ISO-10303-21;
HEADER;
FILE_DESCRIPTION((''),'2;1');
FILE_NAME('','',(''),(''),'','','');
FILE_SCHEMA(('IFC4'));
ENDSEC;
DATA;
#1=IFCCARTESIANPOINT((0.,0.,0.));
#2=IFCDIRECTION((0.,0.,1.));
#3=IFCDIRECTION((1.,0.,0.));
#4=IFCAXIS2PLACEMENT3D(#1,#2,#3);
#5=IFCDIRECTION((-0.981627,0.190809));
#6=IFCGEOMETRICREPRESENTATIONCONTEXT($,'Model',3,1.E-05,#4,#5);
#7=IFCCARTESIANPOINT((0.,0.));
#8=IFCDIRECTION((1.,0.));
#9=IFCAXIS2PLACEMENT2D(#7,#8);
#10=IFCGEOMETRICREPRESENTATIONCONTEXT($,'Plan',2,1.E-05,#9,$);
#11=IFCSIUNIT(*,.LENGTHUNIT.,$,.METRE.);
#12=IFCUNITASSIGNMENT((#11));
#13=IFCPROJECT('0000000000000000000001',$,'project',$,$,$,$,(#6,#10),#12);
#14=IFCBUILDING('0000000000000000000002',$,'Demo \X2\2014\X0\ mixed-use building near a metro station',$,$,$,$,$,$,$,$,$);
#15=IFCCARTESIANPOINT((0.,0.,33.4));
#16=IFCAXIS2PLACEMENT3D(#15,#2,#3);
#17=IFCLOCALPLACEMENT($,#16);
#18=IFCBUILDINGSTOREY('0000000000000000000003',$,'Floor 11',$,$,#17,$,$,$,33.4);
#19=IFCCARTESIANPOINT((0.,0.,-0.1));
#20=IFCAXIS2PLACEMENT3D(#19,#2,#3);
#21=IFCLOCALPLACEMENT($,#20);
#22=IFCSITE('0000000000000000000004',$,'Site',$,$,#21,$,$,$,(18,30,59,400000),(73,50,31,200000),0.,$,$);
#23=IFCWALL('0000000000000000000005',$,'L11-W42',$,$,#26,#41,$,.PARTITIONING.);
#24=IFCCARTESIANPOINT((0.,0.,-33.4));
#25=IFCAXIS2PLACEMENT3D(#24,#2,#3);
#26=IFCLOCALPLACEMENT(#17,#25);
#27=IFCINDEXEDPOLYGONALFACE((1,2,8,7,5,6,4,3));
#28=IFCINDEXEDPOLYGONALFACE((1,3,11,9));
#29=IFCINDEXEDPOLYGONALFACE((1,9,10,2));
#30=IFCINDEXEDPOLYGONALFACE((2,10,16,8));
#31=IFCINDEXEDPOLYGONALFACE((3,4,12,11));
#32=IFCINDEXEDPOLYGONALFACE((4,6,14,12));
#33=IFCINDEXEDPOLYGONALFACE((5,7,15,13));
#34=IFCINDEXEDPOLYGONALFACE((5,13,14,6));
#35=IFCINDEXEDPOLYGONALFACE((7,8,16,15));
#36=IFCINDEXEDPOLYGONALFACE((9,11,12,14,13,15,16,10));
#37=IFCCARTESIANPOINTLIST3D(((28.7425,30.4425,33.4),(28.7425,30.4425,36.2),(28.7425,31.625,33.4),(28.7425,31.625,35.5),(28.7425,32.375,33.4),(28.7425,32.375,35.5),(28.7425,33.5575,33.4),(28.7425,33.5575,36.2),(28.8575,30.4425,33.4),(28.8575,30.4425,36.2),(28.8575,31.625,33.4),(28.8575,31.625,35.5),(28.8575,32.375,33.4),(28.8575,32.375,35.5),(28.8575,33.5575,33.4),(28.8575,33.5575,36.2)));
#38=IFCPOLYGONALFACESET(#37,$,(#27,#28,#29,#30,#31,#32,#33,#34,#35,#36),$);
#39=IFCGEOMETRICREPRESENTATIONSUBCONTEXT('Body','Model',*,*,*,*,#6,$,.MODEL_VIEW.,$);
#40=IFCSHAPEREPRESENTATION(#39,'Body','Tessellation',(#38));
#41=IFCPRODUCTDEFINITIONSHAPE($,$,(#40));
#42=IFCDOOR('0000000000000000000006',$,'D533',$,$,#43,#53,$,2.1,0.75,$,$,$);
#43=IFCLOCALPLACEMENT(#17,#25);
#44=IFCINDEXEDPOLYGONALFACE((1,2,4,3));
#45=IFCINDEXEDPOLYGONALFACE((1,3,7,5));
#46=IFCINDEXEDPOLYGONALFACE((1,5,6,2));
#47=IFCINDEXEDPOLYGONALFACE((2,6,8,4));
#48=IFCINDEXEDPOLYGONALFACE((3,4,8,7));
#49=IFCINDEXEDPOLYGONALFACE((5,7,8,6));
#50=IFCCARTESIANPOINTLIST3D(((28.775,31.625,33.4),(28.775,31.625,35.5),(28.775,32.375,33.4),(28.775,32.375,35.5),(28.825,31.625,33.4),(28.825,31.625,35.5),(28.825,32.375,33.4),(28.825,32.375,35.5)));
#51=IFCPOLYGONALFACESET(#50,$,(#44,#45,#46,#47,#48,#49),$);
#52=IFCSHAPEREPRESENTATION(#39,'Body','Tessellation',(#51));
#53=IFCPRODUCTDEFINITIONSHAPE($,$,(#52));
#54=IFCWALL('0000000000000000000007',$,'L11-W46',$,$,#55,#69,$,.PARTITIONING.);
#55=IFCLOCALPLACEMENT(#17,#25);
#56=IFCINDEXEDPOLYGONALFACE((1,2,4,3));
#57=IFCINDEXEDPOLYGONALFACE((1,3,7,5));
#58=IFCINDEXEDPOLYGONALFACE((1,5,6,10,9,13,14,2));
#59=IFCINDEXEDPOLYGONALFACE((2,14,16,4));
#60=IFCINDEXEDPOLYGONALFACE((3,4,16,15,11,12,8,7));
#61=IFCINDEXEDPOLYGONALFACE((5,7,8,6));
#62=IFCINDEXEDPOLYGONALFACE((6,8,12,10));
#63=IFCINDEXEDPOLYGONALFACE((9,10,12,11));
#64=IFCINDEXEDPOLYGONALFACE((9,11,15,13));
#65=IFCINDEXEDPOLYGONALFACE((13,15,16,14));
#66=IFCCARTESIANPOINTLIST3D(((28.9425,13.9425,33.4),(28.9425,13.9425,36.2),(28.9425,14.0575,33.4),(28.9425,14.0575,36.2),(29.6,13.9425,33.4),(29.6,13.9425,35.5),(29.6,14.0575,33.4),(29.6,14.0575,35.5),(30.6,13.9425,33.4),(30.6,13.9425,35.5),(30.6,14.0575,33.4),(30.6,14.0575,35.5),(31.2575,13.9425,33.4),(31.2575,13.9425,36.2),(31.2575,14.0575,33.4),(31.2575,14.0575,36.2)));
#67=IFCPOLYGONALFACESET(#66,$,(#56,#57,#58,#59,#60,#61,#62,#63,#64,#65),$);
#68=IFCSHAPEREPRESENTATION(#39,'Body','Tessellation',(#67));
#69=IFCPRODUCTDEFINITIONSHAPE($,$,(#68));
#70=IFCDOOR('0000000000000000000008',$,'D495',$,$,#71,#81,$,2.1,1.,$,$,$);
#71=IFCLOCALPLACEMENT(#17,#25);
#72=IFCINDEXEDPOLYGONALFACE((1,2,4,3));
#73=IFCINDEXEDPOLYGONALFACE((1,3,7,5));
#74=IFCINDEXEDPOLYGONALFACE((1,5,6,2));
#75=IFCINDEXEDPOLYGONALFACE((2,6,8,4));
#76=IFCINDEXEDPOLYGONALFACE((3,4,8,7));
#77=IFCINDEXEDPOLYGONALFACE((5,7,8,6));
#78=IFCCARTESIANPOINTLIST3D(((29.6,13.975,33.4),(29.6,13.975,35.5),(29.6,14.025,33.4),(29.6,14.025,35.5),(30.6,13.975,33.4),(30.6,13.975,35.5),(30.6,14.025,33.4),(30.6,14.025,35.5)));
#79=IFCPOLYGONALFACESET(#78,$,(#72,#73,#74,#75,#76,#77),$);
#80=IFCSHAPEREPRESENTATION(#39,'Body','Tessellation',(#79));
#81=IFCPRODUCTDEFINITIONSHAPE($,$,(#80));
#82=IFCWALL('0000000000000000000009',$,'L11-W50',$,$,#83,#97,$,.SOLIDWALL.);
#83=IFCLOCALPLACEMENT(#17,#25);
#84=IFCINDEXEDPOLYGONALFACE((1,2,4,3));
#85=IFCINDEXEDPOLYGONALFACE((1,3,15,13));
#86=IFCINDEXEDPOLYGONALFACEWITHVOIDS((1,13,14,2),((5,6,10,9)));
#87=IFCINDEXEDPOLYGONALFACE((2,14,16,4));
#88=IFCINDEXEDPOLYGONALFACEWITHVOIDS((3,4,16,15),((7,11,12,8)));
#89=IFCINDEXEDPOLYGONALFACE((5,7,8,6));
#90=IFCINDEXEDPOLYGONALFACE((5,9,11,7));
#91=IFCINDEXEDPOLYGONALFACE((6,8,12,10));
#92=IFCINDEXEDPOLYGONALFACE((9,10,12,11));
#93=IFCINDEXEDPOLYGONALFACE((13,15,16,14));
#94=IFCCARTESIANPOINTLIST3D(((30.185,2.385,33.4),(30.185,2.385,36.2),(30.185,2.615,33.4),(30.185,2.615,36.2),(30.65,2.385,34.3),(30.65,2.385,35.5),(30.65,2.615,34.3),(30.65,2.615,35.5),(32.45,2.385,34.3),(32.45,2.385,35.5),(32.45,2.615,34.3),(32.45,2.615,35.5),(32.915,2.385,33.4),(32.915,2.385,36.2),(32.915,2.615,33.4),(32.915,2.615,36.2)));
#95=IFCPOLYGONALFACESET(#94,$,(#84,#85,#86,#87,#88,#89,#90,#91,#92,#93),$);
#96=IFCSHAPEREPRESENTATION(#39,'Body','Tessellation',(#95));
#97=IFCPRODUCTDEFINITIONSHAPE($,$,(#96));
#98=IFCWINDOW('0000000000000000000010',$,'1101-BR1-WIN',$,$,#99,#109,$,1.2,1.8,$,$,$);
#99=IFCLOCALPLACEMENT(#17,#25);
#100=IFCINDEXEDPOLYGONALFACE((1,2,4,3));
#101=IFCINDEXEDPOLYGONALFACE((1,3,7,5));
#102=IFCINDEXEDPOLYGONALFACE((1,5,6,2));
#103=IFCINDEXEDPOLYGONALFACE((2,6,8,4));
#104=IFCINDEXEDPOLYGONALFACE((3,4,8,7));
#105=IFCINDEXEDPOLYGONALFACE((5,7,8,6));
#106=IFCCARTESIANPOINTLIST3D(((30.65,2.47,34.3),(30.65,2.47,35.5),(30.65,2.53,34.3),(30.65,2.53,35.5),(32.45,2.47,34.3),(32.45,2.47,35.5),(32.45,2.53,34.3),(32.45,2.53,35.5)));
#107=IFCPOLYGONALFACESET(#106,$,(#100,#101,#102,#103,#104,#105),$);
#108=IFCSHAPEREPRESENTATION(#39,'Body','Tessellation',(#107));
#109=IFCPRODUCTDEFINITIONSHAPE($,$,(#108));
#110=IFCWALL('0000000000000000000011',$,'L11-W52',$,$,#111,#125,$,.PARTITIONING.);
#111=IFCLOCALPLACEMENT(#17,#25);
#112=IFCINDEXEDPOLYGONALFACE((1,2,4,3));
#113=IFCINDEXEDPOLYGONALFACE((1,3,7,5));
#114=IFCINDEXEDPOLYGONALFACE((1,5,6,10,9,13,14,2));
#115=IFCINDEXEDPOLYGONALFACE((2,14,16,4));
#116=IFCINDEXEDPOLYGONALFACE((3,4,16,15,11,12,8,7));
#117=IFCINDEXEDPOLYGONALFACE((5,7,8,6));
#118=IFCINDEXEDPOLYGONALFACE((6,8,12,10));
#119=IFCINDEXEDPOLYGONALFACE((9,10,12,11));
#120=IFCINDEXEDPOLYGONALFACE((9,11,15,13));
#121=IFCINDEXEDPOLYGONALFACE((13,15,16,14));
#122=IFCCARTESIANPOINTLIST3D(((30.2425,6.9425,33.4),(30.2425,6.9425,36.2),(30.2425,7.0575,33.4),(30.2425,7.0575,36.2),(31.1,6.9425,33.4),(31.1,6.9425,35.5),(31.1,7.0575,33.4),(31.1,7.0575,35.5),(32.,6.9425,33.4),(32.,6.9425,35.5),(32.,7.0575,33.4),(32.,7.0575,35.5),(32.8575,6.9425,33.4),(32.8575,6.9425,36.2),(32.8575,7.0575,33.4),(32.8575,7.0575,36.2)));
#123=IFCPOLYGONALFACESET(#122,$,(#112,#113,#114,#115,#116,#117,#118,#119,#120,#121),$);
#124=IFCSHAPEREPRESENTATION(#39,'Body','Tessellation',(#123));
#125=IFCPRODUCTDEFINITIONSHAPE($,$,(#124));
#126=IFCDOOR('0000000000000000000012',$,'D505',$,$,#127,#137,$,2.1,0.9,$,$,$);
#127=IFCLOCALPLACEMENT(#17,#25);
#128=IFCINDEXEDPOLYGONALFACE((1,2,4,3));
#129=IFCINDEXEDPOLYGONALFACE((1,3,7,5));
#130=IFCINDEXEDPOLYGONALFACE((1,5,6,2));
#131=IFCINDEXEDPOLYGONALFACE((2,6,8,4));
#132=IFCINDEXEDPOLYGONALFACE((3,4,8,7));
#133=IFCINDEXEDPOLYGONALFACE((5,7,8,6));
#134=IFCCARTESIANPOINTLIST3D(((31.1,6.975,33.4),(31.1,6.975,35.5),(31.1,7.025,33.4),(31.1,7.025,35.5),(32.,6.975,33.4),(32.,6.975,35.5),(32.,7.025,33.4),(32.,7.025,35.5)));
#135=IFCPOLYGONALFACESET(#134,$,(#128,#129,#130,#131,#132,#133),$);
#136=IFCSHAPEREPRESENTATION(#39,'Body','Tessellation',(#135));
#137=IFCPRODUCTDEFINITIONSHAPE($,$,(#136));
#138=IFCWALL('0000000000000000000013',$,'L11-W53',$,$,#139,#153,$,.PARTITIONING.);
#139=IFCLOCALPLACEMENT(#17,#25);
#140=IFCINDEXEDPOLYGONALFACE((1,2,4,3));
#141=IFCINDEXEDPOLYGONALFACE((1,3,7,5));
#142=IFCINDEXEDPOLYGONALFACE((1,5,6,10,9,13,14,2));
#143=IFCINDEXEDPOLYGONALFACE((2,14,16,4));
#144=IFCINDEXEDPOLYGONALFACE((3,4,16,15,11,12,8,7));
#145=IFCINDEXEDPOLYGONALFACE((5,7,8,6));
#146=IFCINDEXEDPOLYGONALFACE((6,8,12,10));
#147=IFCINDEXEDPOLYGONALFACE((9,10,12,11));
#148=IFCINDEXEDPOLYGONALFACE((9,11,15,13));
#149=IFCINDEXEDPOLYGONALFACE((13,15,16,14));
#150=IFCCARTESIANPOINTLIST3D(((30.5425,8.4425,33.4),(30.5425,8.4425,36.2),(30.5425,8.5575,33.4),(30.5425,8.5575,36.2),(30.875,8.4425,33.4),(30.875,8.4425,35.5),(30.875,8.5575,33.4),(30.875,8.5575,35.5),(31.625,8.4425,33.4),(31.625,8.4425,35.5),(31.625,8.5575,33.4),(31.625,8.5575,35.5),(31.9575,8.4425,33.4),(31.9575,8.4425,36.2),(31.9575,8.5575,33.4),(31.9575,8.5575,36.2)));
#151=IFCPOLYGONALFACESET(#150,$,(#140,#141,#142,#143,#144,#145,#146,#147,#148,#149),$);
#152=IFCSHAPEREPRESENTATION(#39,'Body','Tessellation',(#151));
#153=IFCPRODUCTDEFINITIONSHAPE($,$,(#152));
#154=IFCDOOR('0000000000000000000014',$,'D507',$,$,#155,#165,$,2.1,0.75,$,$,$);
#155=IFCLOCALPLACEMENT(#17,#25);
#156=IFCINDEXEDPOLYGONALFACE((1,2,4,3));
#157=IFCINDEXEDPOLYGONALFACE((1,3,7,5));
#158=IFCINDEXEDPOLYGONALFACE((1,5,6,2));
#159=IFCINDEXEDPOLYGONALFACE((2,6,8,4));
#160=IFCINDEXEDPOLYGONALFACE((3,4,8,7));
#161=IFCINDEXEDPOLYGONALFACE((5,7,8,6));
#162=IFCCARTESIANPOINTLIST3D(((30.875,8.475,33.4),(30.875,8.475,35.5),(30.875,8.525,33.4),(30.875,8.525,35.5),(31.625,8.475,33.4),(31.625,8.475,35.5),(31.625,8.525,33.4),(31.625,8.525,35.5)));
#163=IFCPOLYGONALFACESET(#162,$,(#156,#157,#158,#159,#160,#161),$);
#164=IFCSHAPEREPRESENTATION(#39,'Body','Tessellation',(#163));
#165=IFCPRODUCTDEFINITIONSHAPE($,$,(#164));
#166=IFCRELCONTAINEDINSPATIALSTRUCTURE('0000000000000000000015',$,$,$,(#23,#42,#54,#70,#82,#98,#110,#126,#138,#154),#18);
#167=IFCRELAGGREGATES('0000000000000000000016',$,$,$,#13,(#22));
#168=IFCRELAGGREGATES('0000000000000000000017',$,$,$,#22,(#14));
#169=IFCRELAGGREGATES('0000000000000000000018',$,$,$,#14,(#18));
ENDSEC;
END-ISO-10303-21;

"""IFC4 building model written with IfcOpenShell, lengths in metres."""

from ifc_helpers import new_model, si_unit, direction, frame, origin_with_axes, origin_2d_with_axis, place, context, subcontext, project, spatial, line, indexed_curve, outline, extrude, element, fill, save


model = new_model("IFC4")

# Units and contexts
model_context = context("Model", 3, precision=1e-05, world=origin_with_axes(), true_north=direction((-0.981627, 0.190809)))
plan_context = context("Plan", 2, precision=1e-05, world=origin_2d_with_axis())
body_context = subcontext(model_context, "Body", "Model", "MODEL_VIEW")
ifc_project = project(units=[si_unit("LENGTHUNIT", "METRE")], contexts=[model_context, plan_context])

# Site, building, storey
site_placement = place(None, frame((0.0, 0.0, -0.1), z_axis=(0.0, 0.0, 1.0), x_axis=(1.0, 0.0, 0.0)))
site = spatial("IfcSite", under=ifc_project, at=site_placement, Name="Site", RefLatitude=(18, 30, 59, 400000), RefLongitude=(73, 50, 31, 200000), RefElevation=0.0)
building = spatial("IfcBuilding", under=site, Name="Demo — mixed-use building near a metro station")
storey_placement = place(None, frame((0.0, 0.0, 33.4), z_axis=(0.0, 0.0, 1.0), x_axis=(1.0, 0.0, 0.0)))
storey = spatial("IfcBuildingStorey", under=building, at=storey_placement, Name="Floor 11", Elevation=33.4)

# Wall, opening, door
wall_1_placement = place(storey_placement, frame((0.0, 0.0, -33.4), z_axis=(0.0, 0.0, 1.0), x_axis=(1.0, 0.0, 0.0)))
wall_1 = element("IfcWall", 1, at=wall_1_placement, inside=storey, Name="L11-W42", PredefinedType="PARTITIONING", context=body_context, shape_type="SweptSolid", body=[
    extrude(outline(indexed_curve([(28.7425, 30.4425), (28.7425, 33.5575), (28.8575, 33.5575), (28.8575, 30.4425)], segments=[line(1, 2, 3, 4, 1)])), frame((0.0, 0.0, 33.4), z_axis=(0.0, 0.0, 1.0), x_axis=(1.0, 0.0, 0.0)), (0.0, 0.0, 1.0), 2.8),
])
opening_1_placement = place(wall_1_placement, origin_with_axes())
opening_1 = element("IfcOpeningElement", 2, at=opening_1_placement, cuts=wall_1, context=body_context, shape_type="SweptSolid", body=[
    extrude(outline(indexed_curve([(28.6925, 31.625), (28.6925, 32.375), (28.9075, 32.375), (28.9075, 31.625)], segments=[line(1, 2, 3, 4, 1)])), frame((0.0, 0.0, 33.4), z_axis=(0.0, 0.0, 1.0), x_axis=(1.0, 0.0, 0.0)), (0.0, 0.0, 1.0), 2.1),
])
door_1_placement = place(storey_placement, frame((0.0, 0.0, -33.4), z_axis=(0.0, 0.0, 1.0), x_axis=(1.0, 0.0, 0.0)))
door_1 = element("IfcDoor", 3, at=door_1_placement, inside=storey, Name="D533", OverallHeight=2.1, OverallWidth=0.75, context=body_context, shape_type="SweptSolid", body=[
    extrude(outline(indexed_curve([(28.775, 31.625), (28.775, 32.375), (28.825, 32.375), (28.825, 31.625)], segments=[line(1, 2, 3, 4, 1)])), frame((0.0, 0.0, 33.4), z_axis=(0.0, 0.0, 1.0), x_axis=(1.0, 0.0, 0.0)), (0.0, 0.0, 1.0), 2.1),
])
fill(opening_1, door_1)

# Wall, opening, door
wall_2_placement = place(storey_placement, frame((0.0, 0.0, -33.4), z_axis=(0.0, 0.0, 1.0), x_axis=(1.0, 0.0, 0.0)))
wall_2 = element("IfcWall", 4, at=wall_2_placement, inside=storey, Name="L11-W46", PredefinedType="PARTITIONING", context=body_context, shape_type="SweptSolid", body=[
    extrude(outline(indexed_curve([(31.2575, 13.9425), (28.9425, 13.9425), (28.9425, 14.0575), (31.2575, 14.0575)], segments=[line(1, 2, 3, 4, 1)])), frame((0.0, 0.0, 33.4), z_axis=(0.0, 0.0, 1.0), x_axis=(1.0, 0.0, 0.0)), (0.0, 0.0, 1.0), 2.8),
])
opening_2_placement = place(wall_2_placement, origin_with_axes())
opening_2 = element("IfcOpeningElement", 5, at=opening_2_placement, cuts=wall_2, context=body_context, shape_type="SweptSolid", body=[
    extrude(outline(indexed_curve([(30.6, 13.8925), (29.6, 13.8925), (29.6, 14.1075), (30.6, 14.1075)], segments=[line(1, 2, 3, 4, 1)])), frame((0.0, 0.0, 33.4), z_axis=(0.0, 0.0, 1.0), x_axis=(1.0, 0.0, 0.0)), (0.0, 0.0, 1.0), 2.1),
])
door_2_placement = place(storey_placement, frame((0.0, 0.0, -33.4), z_axis=(0.0, 0.0, 1.0), x_axis=(1.0, 0.0, 0.0)))
door_2 = element("IfcDoor", 6, at=door_2_placement, inside=storey, Name="D495", OverallHeight=2.1, OverallWidth=1.0, context=body_context, shape_type="SweptSolid", body=[
    extrude(outline(indexed_curve([(30.6, 13.975), (29.6, 13.975), (29.6, 14.025), (30.6, 14.025)], segments=[line(1, 2, 3, 4, 1)])), frame((0.0, 0.0, 33.4), z_axis=(0.0, 0.0, 1.0), x_axis=(1.0, 0.0, 0.0)), (0.0, 0.0, 1.0), 2.1),
])
fill(opening_2, door_2)

# Wall, opening, window
wall_3_placement = place(storey_placement, frame((0.0, 0.0, -33.4), z_axis=(0.0, 0.0, 1.0), x_axis=(1.0, 0.0, 0.0)))
wall_3 = element("IfcWall", 7, at=wall_3_placement, inside=storey, Name="L11-W50", PredefinedType="SOLIDWALL", context=body_context, shape_type="SweptSolid", body=[
    extrude(outline(indexed_curve([(30.185, 2.615), (32.915, 2.615), (32.915, 2.385), (30.185, 2.385)], segments=[line(1, 2, 3, 4, 1)])), frame((0.0, 0.0, 33.4), z_axis=(0.0, 0.0, 1.0), x_axis=(1.0, 0.0, 0.0)), (0.0, 0.0, 1.0), 2.8),
])
opening_3_placement = place(wall_3_placement, origin_with_axes())
opening_3 = element("IfcOpeningElement", 8, at=opening_3_placement, cuts=wall_3, context=body_context, shape_type="SweptSolid", body=[
    extrude(outline(indexed_curve([(30.65, 2.665), (32.45, 2.665), (32.45, 2.335), (30.65, 2.335)], segments=[line(1, 2, 3, 4, 1)])), frame((0.0, 0.0, 34.3), z_axis=(0.0, 0.0, 1.0), x_axis=(1.0, 0.0, 0.0)), (0.0, 0.0, 1.0), 1.2),
])
window_placement = place(storey_placement, frame((0.0, 0.0, -33.4), z_axis=(0.0, 0.0, 1.0), x_axis=(1.0, 0.0, 0.0)))
window = element("IfcWindow", 9, at=window_placement, inside=storey, Name="1101-BR1-WIN", OverallHeight=1.2, OverallWidth=1.8, context=body_context, shape_type="SweptSolid", body=[
    extrude(outline(indexed_curve([(30.65, 2.53), (32.45, 2.53), (32.45, 2.47), (30.65, 2.47)], segments=[line(1, 2, 3, 4, 1)])), frame((0.0, 0.0, 34.3), z_axis=(0.0, 0.0, 1.0), x_axis=(1.0, 0.0, 0.0)), (0.0, 0.0, 1.0), 1.2),
])
fill(opening_3, window)

# Walls, openings, doors
wall_4_placement = place(storey_placement, frame((0.0, 0.0, -33.4), z_axis=(0.0, 0.0, 1.0), x_axis=(1.0, 0.0, 0.0)))
wall_4 = element("IfcWall", 10, at=wall_4_placement, inside=storey, Name="L11-W52", PredefinedType="PARTITIONING", context=body_context, shape_type="SweptSolid", body=[
    extrude(outline(indexed_curve([(32.8575, 6.9425), (30.2425, 6.9425), (30.2425, 7.0575), (32.8575, 7.0575)], segments=[line(1, 2, 3, 4, 1)])), frame((0.0, 0.0, 33.4), z_axis=(0.0, 0.0, 1.0), x_axis=(1.0, 0.0, 0.0)), (0.0, 0.0, 1.0), 2.8),
])
opening_4_placement = place(wall_4_placement, origin_with_axes())
opening_4 = element("IfcOpeningElement", 11, at=opening_4_placement, cuts=wall_4, context=body_context, shape_type="SweptSolid", body=[
    extrude(outline(indexed_curve([(32.0, 6.8925), (31.1, 6.8925), (31.1, 7.1075), (32.0, 7.1075)], segments=[line(1, 2, 3, 4, 1)])), frame((0.0, 0.0, 33.4), z_axis=(0.0, 0.0, 1.0), x_axis=(1.0, 0.0, 0.0)), (0.0, 0.0, 1.0), 2.1),
])
door_3_placement = place(storey_placement, frame((0.0, 0.0, -33.4), z_axis=(0.0, 0.0, 1.0), x_axis=(1.0, 0.0, 0.0)))
door_3 = element("IfcDoor", 12, at=door_3_placement, inside=storey, Name="D505", OverallHeight=2.1, OverallWidth=0.9, context=body_context, shape_type="SweptSolid", body=[
    extrude(outline(indexed_curve([(32.0, 6.975), (31.1, 6.975), (31.1, 7.025), (32.0, 7.025)], segments=[line(1, 2, 3, 4, 1)])), frame((0.0, 0.0, 33.4), z_axis=(0.0, 0.0, 1.0), x_axis=(1.0, 0.0, 0.0)), (0.0, 0.0, 1.0), 2.1),
])
fill(opening_4, door_3)
wall_5_placement = place(storey_placement, frame((0.0, 0.0, -33.4), z_axis=(0.0, 0.0, 1.0), x_axis=(1.0, 0.0, 0.0)))
wall_5 = element("IfcWall", 13, at=wall_5_placement, inside=storey, Name="L11-W53", PredefinedType="PARTITIONING", context=body_context, shape_type="SweptSolid", body=[
    extrude(outline(indexed_curve([(31.9575, 8.4425), (30.5425, 8.4425), (30.5425, 8.5575), (31.9575, 8.5575)], segments=[line(1, 2, 3, 4, 1)])), frame((0.0, 0.0, 33.4), z_axis=(0.0, 0.0, 1.0), x_axis=(1.0, 0.0, 0.0)), (0.0, 0.0, 1.0), 2.8),
])
opening_5_placement = place(wall_5_placement, origin_with_axes())
opening_5 = element("IfcOpeningElement", 14, at=opening_5_placement, cuts=wall_5, context=body_context, shape_type="SweptSolid", body=[
    extrude(outline(indexed_curve([(31.625, 8.3925), (30.875, 8.3925), (30.875, 8.6075), (31.625, 8.6075)], segments=[line(1, 2, 3, 4, 1)])), frame((0.0, 0.0, 33.4), z_axis=(0.0, 0.0, 1.0), x_axis=(1.0, 0.0, 0.0)), (0.0, 0.0, 1.0), 2.1),
])
door_4_placement = place(storey_placement, frame((0.0, 0.0, -33.4), z_axis=(0.0, 0.0, 1.0), x_axis=(1.0, 0.0, 0.0)))
door_4 = element("IfcDoor", 15, at=door_4_placement, inside=storey, Name="D507", OverallHeight=2.1, OverallWidth=0.75, context=body_context, shape_type="SweptSolid", body=[
    extrude(outline(indexed_curve([(31.625, 8.475), (30.875, 8.475), (30.875, 8.525), (31.625, 8.525)], segments=[line(1, 2, 3, 4, 1)])), frame((0.0, 0.0, 33.4), z_axis=(0.0, 0.0, 1.0), x_axis=(1.0, 0.0, 0.0)), (0.0, 0.0, 1.0), 2.1),
])
fill(opening_5, door_4)

save(model, "model.ifc")
